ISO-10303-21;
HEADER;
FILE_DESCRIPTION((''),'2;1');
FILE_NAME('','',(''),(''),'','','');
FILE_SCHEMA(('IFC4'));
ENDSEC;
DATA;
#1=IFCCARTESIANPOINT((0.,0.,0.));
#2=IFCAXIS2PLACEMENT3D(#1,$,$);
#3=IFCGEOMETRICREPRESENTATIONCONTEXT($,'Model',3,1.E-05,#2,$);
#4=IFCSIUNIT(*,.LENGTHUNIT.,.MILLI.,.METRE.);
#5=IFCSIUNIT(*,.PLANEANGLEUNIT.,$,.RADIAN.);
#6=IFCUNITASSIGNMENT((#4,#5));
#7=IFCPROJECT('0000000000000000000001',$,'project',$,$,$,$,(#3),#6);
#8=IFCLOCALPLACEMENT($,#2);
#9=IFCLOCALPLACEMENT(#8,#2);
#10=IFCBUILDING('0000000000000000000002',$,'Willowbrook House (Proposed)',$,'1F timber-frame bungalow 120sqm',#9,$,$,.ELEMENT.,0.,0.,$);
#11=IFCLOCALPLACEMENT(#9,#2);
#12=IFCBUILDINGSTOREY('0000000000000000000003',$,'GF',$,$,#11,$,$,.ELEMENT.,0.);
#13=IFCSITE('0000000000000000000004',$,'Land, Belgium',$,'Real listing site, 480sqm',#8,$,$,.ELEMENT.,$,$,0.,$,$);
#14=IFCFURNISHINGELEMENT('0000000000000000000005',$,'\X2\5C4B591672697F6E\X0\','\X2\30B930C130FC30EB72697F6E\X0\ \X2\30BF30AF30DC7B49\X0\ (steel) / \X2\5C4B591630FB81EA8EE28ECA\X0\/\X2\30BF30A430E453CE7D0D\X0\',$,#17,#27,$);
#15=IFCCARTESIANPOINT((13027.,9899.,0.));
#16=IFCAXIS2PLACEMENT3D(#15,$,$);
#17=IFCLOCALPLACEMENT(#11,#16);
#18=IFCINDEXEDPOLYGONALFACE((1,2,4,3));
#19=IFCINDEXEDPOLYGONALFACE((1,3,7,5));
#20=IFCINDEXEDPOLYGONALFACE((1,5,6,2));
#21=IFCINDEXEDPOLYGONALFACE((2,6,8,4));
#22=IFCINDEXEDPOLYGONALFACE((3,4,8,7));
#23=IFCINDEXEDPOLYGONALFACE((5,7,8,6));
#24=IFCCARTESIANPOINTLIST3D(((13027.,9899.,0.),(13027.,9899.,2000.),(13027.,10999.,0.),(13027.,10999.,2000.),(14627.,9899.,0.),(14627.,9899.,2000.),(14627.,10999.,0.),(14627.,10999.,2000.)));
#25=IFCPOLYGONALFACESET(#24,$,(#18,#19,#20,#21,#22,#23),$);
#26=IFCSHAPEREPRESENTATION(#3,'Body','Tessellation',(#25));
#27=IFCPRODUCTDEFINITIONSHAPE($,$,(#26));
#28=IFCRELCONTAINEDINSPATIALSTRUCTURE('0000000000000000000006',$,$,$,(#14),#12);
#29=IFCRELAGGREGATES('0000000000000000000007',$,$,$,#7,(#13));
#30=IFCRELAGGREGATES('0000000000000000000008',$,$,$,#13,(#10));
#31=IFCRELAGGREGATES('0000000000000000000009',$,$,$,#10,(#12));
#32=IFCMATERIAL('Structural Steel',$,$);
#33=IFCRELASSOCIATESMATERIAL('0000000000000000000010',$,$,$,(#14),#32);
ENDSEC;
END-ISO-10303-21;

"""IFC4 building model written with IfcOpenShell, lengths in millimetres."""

from ifc_helpers import new_model, si_unit, frame, frame_2d, origin, place, context, project, spatial, rectangle, extrude, material, element, save


model = new_model("IFC4")

# Units and contexts
model_context = context("Model", 3, precision=1e-05, world=origin())
ifc_project = project(units=[si_unit("LENGTHUNIT", "METRE", prefix="MILLI"), si_unit("PLANEANGLEUNIT", "RADIAN")], contexts=[model_context])

# Site, building, storey
site_placement = place(None, origin())
site = spatial("IfcSite", under=ifc_project, at=site_placement, Name="Land, Belgium", ObjectType="Real listing site, 480sqm", CompositionType="ELEMENT", RefElevation=0.0)
building_placement = place(site_placement, origin())
building = spatial("IfcBuilding", under=site, at=building_placement, Name="Willowbrook House (Proposed)", ObjectType="1F timber-frame bungalow 120sqm", CompositionType="ELEMENT", ElevationOfRefHeight=0.0, ElevationOfTerrain=0.0)
storey_placement = place(building_placement, origin())
storey = spatial("IfcBuildingStorey", under=building, at=storey_placement, Name="GF", CompositionType="ELEMENT", Elevation=0.0)

# Shared definitions
ifc_material_1 = material(Name="Structural Steel")

# Furnishing element
furnishing_placement = place(storey_placement, frame((13027.0, 9899.0, 0.0)))
element("IfcFurnishingElement", 1, at=furnishing_placement, inside=storey, material=ifc_material_1, Name="屋外物置", Description="スチール物置 タクボ等 (steel) / 屋外・自転車/タイヤ収納", context=model_context, shape_type="SweptSolid", body=[
    extrude(rectangle(XDim=1600.0, YDim=1100.0, at=frame_2d((800.0, 550.0))), frame((13027.0, 9899.0, 0.0)), (0.0, 0.0, 1.0), 2000.0),
])

save(model, "model.ifc")
